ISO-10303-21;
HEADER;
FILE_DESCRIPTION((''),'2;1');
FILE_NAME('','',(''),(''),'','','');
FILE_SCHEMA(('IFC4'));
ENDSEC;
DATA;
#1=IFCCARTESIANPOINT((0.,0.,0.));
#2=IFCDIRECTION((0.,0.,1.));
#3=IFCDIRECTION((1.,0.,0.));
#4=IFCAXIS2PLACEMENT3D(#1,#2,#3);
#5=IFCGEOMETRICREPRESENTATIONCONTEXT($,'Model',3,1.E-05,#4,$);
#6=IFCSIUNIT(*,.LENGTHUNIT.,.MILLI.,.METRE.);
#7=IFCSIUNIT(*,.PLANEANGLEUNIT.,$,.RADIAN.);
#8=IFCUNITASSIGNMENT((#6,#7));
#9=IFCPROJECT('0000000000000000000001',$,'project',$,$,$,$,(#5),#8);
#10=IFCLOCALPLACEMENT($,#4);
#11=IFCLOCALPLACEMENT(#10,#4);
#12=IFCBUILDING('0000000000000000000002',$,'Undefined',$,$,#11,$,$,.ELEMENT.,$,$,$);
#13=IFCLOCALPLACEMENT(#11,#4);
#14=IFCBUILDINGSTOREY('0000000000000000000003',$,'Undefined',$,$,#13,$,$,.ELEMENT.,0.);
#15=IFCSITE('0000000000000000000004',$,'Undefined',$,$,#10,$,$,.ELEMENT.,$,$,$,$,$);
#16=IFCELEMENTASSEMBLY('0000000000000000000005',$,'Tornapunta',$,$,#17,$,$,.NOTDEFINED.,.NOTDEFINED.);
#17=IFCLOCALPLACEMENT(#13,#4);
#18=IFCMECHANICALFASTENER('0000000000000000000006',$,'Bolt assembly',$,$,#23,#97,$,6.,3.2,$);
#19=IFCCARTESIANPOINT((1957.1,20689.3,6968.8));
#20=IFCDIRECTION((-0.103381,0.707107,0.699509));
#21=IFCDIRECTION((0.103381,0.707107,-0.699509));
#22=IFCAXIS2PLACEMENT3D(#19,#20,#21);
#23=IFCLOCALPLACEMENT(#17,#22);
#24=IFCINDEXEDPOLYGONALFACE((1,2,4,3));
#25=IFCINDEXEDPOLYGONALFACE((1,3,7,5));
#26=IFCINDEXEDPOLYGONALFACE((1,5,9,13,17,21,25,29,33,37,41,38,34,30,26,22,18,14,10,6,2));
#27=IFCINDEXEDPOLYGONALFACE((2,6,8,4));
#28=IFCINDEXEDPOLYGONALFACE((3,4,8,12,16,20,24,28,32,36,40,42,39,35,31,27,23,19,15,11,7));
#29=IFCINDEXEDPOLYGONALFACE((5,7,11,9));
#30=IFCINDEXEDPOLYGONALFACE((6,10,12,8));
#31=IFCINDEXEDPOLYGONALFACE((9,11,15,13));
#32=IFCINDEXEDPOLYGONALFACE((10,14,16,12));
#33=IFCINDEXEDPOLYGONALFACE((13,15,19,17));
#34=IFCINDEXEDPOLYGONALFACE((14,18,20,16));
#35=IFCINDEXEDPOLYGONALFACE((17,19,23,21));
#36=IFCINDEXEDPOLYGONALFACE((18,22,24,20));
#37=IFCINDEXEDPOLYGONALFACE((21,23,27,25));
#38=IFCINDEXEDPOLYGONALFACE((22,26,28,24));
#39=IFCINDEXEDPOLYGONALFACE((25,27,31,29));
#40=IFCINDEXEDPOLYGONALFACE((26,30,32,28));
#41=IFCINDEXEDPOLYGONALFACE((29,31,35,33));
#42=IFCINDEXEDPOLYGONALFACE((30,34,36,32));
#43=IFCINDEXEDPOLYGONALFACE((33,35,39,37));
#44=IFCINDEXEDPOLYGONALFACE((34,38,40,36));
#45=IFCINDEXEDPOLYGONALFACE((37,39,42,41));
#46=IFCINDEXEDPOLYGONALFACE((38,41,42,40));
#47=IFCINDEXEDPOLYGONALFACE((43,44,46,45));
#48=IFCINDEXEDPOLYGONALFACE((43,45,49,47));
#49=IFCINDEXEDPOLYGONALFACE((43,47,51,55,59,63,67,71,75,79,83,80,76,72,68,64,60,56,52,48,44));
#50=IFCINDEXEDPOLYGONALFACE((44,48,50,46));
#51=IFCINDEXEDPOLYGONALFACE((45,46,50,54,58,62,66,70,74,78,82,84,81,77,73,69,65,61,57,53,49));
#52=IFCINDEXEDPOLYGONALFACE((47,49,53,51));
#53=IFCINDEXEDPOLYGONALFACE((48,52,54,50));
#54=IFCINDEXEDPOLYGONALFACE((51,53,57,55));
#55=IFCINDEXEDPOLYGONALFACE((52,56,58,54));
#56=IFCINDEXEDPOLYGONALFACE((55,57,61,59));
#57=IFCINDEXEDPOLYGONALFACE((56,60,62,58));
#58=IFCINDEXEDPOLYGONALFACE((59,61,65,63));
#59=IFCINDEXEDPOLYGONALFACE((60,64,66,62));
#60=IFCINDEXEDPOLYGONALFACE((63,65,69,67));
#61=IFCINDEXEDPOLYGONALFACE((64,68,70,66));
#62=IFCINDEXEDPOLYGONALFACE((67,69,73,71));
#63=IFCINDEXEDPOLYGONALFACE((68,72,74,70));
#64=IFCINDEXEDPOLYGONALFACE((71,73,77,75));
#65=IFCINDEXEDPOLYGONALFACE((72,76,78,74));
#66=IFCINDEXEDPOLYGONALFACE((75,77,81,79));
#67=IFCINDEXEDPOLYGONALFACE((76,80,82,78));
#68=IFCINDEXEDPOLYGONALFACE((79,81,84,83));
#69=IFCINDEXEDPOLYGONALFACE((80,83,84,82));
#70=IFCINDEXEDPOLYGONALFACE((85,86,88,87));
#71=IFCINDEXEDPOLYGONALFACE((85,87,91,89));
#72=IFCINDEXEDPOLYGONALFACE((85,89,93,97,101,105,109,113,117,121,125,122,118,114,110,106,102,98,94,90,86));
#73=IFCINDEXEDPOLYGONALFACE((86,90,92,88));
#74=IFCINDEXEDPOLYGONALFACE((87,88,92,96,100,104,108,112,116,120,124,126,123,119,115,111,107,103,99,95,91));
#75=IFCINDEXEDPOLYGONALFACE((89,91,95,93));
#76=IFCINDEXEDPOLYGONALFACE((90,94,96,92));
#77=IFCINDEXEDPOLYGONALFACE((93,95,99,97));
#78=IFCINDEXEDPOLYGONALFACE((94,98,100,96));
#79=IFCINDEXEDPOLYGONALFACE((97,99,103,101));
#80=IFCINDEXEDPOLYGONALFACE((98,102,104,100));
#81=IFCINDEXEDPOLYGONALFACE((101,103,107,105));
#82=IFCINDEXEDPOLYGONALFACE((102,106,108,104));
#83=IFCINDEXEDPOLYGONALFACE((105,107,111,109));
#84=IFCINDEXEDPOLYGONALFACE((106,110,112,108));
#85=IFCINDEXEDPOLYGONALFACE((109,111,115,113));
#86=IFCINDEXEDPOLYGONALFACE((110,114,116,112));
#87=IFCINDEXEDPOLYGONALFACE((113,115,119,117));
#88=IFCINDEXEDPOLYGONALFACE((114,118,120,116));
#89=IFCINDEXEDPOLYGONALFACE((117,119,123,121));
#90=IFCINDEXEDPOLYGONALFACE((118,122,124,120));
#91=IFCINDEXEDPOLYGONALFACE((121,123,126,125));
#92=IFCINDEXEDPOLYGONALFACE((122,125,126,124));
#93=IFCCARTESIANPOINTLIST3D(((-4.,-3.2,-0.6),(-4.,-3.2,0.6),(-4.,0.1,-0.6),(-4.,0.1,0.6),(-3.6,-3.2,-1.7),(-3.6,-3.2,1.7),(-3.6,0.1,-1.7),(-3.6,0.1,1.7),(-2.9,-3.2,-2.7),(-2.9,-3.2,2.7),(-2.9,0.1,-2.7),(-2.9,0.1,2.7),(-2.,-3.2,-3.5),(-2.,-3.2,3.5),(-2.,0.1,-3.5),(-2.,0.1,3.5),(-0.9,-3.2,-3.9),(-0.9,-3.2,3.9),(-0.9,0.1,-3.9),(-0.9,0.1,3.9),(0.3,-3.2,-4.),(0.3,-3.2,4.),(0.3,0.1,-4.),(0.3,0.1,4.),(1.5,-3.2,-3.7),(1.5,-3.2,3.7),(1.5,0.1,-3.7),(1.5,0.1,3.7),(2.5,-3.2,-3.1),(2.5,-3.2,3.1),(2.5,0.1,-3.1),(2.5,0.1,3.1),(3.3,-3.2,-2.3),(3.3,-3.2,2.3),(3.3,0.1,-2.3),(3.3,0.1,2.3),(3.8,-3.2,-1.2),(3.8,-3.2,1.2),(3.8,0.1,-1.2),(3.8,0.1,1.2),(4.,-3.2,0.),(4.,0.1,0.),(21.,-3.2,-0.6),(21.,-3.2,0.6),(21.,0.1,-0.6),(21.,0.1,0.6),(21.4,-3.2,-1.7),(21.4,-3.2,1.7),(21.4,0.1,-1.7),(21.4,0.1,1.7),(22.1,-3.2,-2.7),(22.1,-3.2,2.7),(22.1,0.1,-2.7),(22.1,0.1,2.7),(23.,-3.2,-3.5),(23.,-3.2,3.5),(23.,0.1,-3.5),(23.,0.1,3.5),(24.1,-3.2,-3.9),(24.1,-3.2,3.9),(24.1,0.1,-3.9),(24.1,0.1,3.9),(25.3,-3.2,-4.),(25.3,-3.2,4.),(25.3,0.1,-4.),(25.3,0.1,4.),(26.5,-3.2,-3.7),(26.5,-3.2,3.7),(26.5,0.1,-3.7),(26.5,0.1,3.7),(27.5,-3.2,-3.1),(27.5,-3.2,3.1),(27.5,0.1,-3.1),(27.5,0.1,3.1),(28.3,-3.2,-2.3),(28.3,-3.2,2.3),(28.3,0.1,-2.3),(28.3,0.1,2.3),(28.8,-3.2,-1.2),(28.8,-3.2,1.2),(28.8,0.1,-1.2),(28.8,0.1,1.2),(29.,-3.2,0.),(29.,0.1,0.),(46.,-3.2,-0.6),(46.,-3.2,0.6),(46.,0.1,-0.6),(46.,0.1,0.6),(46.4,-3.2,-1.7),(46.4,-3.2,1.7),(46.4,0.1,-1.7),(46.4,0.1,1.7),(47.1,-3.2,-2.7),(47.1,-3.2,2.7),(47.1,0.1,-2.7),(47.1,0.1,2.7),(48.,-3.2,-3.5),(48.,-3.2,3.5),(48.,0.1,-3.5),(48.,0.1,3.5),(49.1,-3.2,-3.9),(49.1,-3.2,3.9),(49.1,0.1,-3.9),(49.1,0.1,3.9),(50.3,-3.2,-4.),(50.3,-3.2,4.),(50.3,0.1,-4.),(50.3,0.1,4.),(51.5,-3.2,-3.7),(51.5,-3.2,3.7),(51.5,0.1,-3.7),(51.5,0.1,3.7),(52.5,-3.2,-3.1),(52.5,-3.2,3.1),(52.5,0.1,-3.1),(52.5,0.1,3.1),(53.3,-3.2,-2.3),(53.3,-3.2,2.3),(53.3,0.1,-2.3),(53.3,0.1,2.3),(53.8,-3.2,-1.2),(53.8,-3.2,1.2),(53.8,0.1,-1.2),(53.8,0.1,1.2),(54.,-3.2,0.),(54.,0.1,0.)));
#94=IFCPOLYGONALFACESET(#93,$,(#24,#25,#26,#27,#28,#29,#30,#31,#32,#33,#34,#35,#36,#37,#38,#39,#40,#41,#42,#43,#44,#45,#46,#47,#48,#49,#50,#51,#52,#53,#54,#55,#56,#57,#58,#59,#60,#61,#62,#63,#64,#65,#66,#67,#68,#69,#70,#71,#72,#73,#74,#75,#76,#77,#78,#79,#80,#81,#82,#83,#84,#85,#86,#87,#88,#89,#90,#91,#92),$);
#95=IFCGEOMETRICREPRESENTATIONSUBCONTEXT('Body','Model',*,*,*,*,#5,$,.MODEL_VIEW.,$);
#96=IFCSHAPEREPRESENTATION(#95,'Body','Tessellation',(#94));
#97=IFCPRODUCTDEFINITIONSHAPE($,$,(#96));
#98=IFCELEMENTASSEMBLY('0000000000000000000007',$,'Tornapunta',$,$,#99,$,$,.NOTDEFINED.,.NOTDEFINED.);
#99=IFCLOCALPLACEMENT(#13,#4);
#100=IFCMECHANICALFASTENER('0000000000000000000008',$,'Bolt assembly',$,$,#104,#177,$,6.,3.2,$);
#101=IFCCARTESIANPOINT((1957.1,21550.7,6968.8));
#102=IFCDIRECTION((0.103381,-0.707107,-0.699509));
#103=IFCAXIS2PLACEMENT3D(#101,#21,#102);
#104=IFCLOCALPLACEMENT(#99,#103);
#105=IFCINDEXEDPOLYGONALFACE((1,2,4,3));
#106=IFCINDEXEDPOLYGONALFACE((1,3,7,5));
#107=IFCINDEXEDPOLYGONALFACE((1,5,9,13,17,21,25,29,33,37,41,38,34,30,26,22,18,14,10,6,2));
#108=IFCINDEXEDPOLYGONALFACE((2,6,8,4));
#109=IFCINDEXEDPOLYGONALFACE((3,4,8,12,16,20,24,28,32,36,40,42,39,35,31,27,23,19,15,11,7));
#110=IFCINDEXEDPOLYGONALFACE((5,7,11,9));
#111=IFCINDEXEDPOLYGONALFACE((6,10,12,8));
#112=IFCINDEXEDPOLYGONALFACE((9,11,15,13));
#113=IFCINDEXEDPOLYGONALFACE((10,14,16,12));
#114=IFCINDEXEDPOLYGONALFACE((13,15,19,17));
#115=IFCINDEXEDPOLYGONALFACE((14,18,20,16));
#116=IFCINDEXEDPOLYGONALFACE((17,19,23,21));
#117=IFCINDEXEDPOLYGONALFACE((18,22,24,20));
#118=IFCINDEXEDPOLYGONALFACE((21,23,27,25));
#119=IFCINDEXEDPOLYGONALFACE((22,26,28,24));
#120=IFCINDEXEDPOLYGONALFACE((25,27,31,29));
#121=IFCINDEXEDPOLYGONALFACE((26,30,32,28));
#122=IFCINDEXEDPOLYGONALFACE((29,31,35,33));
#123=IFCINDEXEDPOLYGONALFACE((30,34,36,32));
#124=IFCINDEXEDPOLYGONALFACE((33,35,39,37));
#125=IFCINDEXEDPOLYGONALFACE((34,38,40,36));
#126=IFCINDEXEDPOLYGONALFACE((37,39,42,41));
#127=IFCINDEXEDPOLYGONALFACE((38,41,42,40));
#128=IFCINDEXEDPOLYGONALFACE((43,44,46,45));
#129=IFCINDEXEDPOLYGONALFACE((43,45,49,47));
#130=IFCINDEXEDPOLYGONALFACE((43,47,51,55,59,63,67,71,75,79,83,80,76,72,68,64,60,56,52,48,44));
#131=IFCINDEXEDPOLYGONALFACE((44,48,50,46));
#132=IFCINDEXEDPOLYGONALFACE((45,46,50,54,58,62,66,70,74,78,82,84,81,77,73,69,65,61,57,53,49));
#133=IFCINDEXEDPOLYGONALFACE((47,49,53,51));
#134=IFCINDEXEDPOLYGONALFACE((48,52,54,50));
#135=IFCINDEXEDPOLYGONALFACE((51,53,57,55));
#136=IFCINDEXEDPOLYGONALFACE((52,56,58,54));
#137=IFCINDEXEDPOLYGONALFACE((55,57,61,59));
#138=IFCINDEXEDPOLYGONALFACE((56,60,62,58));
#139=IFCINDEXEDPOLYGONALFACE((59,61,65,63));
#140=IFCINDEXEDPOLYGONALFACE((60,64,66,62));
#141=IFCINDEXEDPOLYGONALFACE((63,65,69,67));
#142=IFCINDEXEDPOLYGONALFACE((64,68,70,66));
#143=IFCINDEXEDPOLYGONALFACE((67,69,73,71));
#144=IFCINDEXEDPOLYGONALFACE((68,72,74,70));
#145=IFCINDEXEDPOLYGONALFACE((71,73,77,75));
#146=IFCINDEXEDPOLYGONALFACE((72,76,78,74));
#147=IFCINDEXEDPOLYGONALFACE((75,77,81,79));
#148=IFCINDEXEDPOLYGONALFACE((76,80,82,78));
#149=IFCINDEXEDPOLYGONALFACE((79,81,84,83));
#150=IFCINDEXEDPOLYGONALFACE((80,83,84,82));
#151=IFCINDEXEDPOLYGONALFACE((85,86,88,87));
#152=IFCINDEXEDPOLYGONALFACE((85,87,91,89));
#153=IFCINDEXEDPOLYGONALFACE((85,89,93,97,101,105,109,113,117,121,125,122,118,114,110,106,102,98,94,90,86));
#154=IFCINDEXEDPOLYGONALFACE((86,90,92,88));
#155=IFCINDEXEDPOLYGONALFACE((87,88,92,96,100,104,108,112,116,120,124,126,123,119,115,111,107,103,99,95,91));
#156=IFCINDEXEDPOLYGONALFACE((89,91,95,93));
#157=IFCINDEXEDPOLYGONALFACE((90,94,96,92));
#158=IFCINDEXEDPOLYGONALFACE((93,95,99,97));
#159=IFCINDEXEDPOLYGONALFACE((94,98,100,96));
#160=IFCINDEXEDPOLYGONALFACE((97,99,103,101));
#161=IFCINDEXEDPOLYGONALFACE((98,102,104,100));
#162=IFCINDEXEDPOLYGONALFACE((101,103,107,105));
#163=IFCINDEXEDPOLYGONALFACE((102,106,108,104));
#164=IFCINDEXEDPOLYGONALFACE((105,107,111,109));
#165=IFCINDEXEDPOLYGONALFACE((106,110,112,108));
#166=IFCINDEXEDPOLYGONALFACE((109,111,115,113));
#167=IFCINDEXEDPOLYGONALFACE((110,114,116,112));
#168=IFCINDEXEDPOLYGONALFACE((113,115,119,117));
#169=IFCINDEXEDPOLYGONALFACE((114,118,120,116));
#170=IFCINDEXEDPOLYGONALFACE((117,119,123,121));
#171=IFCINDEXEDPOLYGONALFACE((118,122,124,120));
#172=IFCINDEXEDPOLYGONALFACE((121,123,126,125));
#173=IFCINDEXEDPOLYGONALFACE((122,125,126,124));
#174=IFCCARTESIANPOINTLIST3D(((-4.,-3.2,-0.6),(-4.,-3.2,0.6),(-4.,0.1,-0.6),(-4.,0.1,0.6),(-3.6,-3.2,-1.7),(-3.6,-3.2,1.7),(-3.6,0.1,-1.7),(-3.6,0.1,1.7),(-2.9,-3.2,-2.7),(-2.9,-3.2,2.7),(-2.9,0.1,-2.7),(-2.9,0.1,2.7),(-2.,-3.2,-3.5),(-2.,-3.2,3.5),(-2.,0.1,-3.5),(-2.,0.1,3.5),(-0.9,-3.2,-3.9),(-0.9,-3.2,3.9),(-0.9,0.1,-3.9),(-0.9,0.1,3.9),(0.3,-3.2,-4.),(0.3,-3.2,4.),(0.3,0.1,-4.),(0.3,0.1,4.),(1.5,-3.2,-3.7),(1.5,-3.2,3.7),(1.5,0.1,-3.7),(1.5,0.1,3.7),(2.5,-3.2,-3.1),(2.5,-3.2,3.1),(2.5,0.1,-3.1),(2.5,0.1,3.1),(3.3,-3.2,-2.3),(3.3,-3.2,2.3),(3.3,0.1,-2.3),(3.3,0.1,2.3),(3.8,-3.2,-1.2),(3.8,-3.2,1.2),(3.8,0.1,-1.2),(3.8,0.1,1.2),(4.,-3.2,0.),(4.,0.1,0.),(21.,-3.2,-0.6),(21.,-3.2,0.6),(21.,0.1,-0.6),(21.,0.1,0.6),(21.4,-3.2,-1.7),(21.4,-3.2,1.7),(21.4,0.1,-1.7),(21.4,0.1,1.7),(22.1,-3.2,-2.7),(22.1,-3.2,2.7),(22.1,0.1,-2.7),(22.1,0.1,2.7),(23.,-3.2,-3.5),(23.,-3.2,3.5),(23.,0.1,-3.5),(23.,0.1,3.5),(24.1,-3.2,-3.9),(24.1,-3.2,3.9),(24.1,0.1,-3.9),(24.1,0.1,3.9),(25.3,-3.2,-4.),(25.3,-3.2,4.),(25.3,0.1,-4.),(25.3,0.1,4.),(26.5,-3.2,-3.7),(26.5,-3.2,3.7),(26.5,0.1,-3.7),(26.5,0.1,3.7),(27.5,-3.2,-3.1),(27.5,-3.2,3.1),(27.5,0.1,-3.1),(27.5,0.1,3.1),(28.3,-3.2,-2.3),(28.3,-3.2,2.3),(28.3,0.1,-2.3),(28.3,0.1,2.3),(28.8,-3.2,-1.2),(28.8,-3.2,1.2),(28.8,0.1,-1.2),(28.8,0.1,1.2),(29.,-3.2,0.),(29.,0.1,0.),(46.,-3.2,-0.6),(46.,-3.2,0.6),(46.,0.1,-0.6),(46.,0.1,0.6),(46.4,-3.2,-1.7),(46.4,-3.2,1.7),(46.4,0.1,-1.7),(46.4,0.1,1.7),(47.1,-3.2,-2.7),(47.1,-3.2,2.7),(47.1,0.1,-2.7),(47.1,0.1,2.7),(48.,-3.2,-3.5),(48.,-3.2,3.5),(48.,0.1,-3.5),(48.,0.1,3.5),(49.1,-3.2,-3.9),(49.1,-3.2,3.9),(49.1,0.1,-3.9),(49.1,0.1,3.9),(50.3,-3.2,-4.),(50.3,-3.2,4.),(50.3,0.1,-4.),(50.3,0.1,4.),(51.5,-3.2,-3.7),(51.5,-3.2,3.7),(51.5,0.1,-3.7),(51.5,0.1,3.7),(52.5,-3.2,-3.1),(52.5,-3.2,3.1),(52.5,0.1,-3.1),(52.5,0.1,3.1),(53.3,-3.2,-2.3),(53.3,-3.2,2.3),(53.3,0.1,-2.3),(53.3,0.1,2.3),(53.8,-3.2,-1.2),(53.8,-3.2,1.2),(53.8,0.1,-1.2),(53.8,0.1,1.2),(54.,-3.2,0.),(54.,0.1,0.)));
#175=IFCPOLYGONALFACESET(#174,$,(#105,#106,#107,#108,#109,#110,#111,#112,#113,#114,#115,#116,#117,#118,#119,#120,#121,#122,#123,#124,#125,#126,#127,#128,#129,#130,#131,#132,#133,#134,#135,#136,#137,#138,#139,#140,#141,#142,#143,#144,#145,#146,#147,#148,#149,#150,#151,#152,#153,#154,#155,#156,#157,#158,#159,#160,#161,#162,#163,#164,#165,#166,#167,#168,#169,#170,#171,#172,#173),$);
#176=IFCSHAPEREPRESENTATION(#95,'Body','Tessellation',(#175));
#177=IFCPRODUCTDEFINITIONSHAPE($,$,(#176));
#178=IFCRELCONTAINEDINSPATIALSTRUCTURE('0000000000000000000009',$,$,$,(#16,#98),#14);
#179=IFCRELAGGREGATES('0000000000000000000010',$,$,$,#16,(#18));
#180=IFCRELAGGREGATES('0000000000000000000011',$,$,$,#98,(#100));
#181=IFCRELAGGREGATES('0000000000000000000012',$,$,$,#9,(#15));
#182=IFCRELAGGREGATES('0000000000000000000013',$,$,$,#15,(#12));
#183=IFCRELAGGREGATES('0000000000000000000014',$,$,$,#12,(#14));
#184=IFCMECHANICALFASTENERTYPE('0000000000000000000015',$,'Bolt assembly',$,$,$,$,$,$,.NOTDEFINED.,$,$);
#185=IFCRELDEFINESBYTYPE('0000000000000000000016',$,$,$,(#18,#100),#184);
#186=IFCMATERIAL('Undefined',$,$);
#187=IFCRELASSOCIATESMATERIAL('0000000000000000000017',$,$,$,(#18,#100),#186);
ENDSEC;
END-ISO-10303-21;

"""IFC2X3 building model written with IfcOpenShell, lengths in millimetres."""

from ifc_helpers import new_model, si_unit, frame, origin_with_axes, origin_2d_with_axis, place, context, subcontext, project, spatial, circle, extrude, source, transform, mapped, material, type_object, element, aggregate, save


model = new_model("IFC2X3")

# Units and contexts
model_context = context("Model", 3, precision=1e-05, world=origin_with_axes())
body_context = subcontext(model_context, "Body", "Model", "MODEL_VIEW")
ifc_project = project(units=[si_unit("LENGTHUNIT", "METRE", prefix="MILLI"), si_unit("PLANEANGLEUNIT", "RADIAN")], contexts=[model_context])

# Site, building, storey
site_placement = place(None, origin_with_axes())
site = spatial("IfcSite", under=ifc_project, at=site_placement, Name="Undefined", CompositionType="ELEMENT")
building_placement = place(site_placement, origin_with_axes())
building = spatial("IfcBuilding", under=site, at=building_placement, Name="Undefined", CompositionType="ELEMENT")
storey_placement = place(building_placement, origin_with_axes())
storey = spatial("IfcBuildingStorey", under=building, at=storey_placement, Name="Undefined", CompositionType="ELEMENT", Elevation=0.0)

# Shared definitions
ifc_material_1 = material(Name="Undefined")
mechanical_fastener_type = type_object("IfcMechanicalFastenerType", Name="Bolt assembly")

# Element assemblies, mechanical fasteners
assembly_1_placement = place(storey_placement, origin_with_axes())
assembly_1 = element("IfcElementAssembly", 1, at=assembly_1_placement, inside=storey, Name="Tornapunta", AssemblyPlace="NOTDEFINED", PredefinedType="NOTDEFINED")
shared_shape_1 = source(origin_with_axes(), body_context, "Body", "SweptSolid", [
    extrude(circle(Radius=4.0, at=origin_2d_with_axis()), frame((0.0, -3.2, 0.0), z_axis=(0.0, 1.0, 0.0), x_axis=(1.0, 0.0, 0.0)), (0.0, 0.0, 1.0), 3.3),
])
mechanical_fastener_1_placement = place(assembly_1_placement, frame((1957.1, 20689.3, 6968.8), z_axis=(-0.103381, 0.707107, 0.699509), x_axis=(0.103381, 0.707107, -0.699509)))
mechanical_fastener_1 = element("IfcMechanicalFastener", 2, at=mechanical_fastener_1_placement, type_object=mechanical_fastener_type, material=ifc_material_1, Name="Bolt assembly", NominalDiameter=6.0, NominalLength=3.2, context=body_context, shape_type="MappedRepresentation", body=[
    mapped(shared_shape_1, transform((0.0, 0.0, 0.0))),
    mapped(shared_shape_1, transform((25.0, 0.0, 0.0))),
    mapped(shared_shape_1, transform((50.0, 0.0, 0.0))),
])
aggregate(assembly_1, [mechanical_fastener_1])
assembly_2_placement = place(storey_placement, origin_with_axes())
assembly_2 = element("IfcElementAssembly", 3, at=assembly_2_placement, inside=storey, Name="Tornapunta", AssemblyPlace="NOTDEFINED", PredefinedType="NOTDEFINED")
mechanical_fastener_2_placement = place(assembly_2_placement, frame((1957.1, 21550.7, 6968.8), z_axis=(0.103381, 0.707107, -0.699509), x_axis=(0.103381, -0.707107, -0.699509)))
mechanical_fastener_2 = element("IfcMechanicalFastener", 4, at=mechanical_fastener_2_placement, type_object=mechanical_fastener_type, material=ifc_material_1, Name="Bolt assembly", NominalDiameter=6.0, NominalLength=3.2, context=body_context, shape_type="MappedRepresentation", body=[
    mapped(shared_shape_1, transform((0.0, 0.0, 0.0))),
    mapped(shared_shape_1, transform((25.0, 0.0, 0.0))),
    mapped(shared_shape_1, transform((50.0, 0.0, 0.0))),
])
aggregate(assembly_2, [mechanical_fastener_2])

save(model, "model.ifc")
